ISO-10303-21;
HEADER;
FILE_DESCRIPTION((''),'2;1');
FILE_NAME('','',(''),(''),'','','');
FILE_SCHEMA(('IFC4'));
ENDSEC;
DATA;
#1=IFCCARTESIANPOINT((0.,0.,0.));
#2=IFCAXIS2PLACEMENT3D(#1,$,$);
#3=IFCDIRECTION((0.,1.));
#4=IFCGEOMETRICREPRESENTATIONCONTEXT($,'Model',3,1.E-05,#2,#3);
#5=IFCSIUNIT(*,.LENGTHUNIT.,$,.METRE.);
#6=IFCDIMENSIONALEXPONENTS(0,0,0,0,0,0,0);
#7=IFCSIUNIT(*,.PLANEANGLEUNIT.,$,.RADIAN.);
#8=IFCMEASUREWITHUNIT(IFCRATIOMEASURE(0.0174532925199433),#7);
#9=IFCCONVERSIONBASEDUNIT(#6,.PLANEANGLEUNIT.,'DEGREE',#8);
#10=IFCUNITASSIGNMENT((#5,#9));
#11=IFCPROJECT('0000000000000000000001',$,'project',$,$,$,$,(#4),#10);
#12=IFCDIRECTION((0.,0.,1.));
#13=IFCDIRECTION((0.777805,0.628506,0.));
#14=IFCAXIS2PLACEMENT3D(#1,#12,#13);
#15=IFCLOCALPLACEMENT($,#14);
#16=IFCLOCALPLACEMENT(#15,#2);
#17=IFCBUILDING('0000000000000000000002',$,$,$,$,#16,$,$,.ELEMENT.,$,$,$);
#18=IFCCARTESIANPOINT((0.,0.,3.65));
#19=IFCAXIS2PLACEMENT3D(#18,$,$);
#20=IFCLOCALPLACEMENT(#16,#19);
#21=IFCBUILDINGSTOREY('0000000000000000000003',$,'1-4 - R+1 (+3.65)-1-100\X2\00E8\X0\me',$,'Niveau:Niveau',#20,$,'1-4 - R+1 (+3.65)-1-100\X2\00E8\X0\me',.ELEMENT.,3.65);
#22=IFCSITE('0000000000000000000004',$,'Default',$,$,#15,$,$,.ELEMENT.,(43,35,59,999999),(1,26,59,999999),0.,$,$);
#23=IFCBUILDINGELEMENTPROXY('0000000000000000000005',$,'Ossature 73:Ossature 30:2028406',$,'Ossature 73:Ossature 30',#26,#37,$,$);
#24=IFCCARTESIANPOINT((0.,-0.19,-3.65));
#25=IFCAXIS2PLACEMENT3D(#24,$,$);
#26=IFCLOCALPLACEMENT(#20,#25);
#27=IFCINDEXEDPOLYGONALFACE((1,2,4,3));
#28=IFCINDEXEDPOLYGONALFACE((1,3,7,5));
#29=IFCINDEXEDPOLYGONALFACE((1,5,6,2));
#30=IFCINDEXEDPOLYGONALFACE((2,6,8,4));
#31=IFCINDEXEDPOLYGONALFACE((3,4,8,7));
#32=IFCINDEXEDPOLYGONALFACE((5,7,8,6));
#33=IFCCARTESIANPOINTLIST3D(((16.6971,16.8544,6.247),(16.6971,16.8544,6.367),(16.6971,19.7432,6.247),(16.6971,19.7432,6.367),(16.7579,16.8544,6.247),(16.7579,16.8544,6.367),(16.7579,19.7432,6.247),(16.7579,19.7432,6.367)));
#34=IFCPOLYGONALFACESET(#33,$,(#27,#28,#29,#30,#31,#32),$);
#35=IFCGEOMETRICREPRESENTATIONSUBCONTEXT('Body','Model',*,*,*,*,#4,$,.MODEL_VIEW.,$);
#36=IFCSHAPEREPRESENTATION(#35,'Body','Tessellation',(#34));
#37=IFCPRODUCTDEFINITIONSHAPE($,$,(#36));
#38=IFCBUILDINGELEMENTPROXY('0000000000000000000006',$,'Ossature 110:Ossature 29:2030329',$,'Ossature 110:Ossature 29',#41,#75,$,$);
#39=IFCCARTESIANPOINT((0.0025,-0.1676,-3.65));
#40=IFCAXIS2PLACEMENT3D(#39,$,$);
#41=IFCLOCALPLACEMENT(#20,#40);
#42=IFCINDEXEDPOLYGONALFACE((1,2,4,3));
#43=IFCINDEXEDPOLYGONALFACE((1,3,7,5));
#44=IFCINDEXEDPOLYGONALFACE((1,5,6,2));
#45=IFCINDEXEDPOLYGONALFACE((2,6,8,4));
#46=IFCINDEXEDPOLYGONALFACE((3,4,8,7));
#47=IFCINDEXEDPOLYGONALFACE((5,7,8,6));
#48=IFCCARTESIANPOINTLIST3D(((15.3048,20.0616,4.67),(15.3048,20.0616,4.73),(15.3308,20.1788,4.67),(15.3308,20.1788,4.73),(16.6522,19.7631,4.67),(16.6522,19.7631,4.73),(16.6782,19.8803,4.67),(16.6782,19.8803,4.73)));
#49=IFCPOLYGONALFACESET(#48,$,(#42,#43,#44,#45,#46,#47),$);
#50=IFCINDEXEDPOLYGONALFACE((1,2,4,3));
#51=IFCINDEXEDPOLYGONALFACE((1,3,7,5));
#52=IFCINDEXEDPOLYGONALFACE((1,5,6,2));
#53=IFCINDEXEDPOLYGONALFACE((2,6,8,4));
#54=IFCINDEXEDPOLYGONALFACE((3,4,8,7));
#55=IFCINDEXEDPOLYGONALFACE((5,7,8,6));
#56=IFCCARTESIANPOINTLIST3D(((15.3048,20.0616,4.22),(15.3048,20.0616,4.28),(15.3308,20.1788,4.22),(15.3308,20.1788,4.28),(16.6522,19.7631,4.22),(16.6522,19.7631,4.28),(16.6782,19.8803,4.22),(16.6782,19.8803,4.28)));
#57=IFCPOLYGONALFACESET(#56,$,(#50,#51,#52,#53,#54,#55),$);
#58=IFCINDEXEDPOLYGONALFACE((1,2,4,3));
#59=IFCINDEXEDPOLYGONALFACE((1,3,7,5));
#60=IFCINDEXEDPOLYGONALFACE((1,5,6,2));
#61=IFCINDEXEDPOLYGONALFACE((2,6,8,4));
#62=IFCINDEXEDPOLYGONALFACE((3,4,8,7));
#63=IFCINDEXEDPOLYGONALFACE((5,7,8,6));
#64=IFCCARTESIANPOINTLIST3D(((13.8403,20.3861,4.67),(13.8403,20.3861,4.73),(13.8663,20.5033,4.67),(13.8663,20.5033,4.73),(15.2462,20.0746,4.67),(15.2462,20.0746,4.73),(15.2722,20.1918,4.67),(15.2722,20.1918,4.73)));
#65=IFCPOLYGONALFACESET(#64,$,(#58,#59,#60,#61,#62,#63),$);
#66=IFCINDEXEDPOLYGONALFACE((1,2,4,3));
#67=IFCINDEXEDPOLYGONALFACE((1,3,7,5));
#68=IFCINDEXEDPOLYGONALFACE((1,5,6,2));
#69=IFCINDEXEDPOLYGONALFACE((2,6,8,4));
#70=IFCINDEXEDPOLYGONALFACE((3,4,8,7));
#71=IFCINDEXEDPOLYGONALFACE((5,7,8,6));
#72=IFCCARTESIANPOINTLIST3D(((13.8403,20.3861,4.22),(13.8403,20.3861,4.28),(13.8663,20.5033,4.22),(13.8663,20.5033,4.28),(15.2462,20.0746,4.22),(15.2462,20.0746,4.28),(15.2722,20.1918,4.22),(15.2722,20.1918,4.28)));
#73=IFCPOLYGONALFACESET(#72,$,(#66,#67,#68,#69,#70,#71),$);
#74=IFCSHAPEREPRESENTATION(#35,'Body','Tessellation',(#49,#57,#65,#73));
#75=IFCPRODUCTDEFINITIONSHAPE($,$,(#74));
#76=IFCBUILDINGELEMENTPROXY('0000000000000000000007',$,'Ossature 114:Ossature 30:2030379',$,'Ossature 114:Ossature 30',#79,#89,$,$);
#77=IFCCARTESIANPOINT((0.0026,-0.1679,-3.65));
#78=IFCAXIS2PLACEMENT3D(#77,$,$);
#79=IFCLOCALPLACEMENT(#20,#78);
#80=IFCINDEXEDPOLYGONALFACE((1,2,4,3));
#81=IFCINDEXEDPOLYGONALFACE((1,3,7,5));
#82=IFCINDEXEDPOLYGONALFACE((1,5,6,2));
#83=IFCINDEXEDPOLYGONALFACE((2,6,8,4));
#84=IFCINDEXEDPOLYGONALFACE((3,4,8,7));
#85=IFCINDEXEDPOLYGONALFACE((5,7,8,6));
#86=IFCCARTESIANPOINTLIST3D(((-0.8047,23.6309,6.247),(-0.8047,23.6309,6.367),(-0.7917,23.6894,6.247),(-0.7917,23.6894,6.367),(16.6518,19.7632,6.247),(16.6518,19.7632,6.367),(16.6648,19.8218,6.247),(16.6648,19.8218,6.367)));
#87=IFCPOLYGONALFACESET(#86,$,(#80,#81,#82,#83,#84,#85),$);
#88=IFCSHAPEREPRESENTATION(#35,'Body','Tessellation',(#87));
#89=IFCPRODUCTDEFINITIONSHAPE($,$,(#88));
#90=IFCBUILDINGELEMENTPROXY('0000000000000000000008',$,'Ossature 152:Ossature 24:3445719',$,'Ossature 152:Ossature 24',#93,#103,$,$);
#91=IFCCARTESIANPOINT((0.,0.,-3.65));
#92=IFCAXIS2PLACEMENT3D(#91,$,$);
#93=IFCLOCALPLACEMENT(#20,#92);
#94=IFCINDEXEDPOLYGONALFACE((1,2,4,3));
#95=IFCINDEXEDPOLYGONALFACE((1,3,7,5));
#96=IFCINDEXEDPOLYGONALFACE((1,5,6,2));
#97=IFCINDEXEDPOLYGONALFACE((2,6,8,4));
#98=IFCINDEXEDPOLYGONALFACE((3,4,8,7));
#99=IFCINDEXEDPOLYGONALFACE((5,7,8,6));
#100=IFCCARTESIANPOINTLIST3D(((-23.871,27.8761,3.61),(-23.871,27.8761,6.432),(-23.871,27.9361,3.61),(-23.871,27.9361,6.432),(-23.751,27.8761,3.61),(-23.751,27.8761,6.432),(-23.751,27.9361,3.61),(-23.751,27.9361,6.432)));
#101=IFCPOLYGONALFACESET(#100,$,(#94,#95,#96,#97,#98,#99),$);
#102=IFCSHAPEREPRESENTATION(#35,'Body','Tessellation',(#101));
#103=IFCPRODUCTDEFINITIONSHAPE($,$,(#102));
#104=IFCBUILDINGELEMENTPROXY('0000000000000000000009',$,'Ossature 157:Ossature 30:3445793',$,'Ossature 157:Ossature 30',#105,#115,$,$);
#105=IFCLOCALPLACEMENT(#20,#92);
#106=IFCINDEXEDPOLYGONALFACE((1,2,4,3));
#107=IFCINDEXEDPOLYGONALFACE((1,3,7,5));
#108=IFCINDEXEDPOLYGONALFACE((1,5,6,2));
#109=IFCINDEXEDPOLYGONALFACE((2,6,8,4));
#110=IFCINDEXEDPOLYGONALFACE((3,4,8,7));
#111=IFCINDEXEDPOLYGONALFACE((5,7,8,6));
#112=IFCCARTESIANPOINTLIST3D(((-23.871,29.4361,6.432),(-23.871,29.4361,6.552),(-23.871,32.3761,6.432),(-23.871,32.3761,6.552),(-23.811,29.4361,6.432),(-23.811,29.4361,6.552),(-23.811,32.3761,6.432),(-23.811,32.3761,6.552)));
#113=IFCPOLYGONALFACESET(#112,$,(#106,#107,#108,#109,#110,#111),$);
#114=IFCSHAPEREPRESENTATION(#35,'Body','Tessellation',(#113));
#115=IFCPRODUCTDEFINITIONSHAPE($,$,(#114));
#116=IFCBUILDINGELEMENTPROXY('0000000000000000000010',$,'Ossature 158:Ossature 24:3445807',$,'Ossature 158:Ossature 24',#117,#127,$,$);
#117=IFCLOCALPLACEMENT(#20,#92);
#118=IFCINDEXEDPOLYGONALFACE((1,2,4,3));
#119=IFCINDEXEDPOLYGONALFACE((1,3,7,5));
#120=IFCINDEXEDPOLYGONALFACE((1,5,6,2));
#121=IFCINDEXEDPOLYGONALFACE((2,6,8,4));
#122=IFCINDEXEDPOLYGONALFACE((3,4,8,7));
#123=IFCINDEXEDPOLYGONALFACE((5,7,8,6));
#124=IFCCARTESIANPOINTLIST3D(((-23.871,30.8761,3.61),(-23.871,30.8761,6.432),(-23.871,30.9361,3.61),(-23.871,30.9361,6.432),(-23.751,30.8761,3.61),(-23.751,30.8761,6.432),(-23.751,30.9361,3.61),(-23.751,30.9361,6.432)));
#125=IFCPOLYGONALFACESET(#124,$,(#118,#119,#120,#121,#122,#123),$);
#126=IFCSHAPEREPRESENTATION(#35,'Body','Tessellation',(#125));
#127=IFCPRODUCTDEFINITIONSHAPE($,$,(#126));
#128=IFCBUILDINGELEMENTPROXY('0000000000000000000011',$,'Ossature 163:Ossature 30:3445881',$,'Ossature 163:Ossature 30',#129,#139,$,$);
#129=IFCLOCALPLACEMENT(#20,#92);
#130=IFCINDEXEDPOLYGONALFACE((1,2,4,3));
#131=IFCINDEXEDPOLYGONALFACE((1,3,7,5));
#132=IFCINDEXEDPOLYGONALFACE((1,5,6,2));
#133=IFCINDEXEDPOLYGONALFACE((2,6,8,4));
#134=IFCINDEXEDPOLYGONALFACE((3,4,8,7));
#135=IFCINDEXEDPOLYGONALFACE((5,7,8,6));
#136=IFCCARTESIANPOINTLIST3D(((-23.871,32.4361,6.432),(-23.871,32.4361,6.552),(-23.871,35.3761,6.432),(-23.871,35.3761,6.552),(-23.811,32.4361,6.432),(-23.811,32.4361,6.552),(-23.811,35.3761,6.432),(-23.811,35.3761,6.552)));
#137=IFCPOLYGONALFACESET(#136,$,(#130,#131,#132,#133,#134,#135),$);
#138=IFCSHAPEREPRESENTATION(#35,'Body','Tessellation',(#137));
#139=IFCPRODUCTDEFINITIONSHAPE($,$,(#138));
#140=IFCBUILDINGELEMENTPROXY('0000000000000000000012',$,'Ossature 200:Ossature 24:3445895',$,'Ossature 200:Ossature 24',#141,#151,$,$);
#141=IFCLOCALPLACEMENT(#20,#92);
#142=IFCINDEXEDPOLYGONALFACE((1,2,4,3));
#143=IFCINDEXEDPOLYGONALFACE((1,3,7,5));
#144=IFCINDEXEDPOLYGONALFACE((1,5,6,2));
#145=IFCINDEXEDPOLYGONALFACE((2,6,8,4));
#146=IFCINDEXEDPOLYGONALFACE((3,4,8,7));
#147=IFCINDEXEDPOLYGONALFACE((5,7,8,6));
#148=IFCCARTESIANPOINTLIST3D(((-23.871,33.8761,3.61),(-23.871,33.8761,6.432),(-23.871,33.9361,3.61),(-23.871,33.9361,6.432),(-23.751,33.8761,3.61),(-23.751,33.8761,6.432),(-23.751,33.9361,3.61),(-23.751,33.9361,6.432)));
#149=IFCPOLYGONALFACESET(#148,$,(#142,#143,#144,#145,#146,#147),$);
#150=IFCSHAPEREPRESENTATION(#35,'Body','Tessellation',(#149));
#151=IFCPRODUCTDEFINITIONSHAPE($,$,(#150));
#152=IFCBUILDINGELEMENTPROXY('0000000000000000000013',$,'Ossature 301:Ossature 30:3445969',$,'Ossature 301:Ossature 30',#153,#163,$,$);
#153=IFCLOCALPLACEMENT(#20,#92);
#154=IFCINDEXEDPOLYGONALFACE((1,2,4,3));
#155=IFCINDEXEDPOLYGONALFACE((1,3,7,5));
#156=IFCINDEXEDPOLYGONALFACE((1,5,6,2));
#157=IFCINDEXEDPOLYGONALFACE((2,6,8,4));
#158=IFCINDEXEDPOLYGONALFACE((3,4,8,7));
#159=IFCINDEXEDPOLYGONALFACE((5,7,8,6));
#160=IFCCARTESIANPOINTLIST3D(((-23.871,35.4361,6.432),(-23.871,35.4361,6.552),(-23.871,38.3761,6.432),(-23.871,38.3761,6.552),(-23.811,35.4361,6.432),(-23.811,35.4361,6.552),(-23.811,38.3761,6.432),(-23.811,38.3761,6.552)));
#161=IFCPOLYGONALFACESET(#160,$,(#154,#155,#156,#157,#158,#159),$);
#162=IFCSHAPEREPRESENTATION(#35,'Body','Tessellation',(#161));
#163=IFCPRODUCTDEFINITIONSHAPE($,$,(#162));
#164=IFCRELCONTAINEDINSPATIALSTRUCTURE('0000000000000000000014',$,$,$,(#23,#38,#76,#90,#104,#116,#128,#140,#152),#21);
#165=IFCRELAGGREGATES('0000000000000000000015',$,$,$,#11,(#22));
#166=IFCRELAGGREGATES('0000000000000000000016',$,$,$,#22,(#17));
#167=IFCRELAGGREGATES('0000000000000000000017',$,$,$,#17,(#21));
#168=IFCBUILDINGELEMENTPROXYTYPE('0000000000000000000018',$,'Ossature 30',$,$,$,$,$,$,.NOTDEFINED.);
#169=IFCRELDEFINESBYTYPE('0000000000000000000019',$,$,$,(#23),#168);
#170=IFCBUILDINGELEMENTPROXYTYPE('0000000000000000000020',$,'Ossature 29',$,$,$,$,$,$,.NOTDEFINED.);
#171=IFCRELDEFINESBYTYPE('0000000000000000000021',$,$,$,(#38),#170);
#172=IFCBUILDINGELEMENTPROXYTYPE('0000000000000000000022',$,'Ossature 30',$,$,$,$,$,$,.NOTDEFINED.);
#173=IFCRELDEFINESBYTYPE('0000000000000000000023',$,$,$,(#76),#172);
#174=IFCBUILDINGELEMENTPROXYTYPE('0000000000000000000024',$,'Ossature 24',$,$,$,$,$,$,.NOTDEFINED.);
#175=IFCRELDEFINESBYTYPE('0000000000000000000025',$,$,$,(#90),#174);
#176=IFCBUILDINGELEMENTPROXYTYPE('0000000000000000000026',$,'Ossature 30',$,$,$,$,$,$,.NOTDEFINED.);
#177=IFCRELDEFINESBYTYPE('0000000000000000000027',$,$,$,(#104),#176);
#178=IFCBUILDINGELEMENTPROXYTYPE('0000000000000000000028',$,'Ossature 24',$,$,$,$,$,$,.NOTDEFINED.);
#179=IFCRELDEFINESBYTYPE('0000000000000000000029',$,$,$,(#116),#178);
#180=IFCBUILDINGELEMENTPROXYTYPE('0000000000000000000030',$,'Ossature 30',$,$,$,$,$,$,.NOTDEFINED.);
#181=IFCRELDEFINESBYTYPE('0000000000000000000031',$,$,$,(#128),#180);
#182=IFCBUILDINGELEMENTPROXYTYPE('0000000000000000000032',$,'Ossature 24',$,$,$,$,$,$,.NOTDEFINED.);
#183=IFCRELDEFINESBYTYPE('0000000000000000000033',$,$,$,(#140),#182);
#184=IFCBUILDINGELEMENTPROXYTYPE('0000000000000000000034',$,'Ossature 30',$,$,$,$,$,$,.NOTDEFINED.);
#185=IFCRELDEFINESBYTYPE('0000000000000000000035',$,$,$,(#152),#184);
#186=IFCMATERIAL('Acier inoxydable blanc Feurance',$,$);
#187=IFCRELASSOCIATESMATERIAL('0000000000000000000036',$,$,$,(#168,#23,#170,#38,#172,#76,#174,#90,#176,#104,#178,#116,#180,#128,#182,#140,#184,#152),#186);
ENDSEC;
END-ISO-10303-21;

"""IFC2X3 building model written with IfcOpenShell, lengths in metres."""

from ifc_helpers import new_model, entity, si_unit, converted_unit, direction, frame, frame_2d, origin, origin_2d_with_axis, place, context, subcontext, project, spatial, rectangle, extrude, source, transform, mapped, material, type_object, type_shapes, element, save


model = new_model("IFC2X3")

# Units and contexts
model_context = context("Model", 3, precision=1e-05, world=origin(), true_north=direction((0.0, 1.0)))
body_context = subcontext(model_context, "Body", "Model", "MODEL_VIEW")
ifc_project = project(units=[si_unit("LENGTHUNIT", "METRE"), converted_unit("PLANEANGLEUNIT", "DEGREE", entity("IfcRatioMeasure", 0.0174532925199433), si_unit("PLANEANGLEUNIT", "RADIAN"), dimensions=[0, 0, 0, 0, 0, 0, 0])], contexts=[model_context])

# Site, building, storey
site_placement = place(None, frame((0.0, 0.0, 0.0), z_axis=(0.0, 0.0, 1.0), x_axis=(0.777805, 0.628506, 0.0)))
site = spatial("IfcSite", under=ifc_project, at=site_placement, Name="Default", CompositionType="ELEMENT", RefLatitude=(43, 35, 59, 999999), RefLongitude=(1, 26, 59, 999999), RefElevation=0.0)
building_placement = place(site_placement, origin())
building = spatial("IfcBuilding", under=site, at=building_placement, CompositionType="ELEMENT")
storey_placement = place(building_placement, frame((0.0, 0.0, 3.65)))
storey = spatial("IfcBuildingStorey", under=building, at=storey_placement, Name="1-4 - R+1 (+3.65)-1-100ème", ObjectType="Niveau:Niveau", LongName="1-4 - R+1 (+3.65)-1-100ème", CompositionType="ELEMENT", Elevation=3.65)

# Building element proxies
ifc_material_1 = material(Name="Acier inoxydable blanc Feurance")
building_element_proxy_type_1 = type_object("IfcBuildingElementProxyType", Name="Ossature 30", PredefinedType="NOTDEFINED", material=ifc_material_1)
shared_shape_1 = source(origin(), body_context, "Body", "SweptSolid", [
    extrude(rectangle(XDim=2.8888, YDim=0.0607, at=frame_2d((0.0, 0.0), x_axis=(1.0, 0.0))), frame((16.7275, 18.2988, 6.247), z_axis=(0.0, 0.0, 1.0), x_axis=(0.0, -1.0, 0.0)), (0.0, 0.0, 1.0), 0.12),
])
type_shapes(building_element_proxy_type_1, [shared_shape_1])
proxy_1_placement = place(storey_placement, frame((0.0, -0.19, -3.65)))
element("IfcBuildingElementProxy", 1, at=proxy_1_placement, inside=storey, type_object=building_element_proxy_type_1, material=ifc_material_1, Name="Ossature 73:Ossature 30:2028406", ObjectType="Ossature 73:Ossature 30", context=body_context, shape_type="MappedRepresentation", body=[
    mapped(shared_shape_1, transform((0.0, 0.0, 0.0), scale=1.0)),
])
building_element_proxy_type_2 = type_object("IfcBuildingElementProxyType", Name="Ossature 29", PredefinedType="NOTDEFINED", material=ifc_material_1)
shared_shape_2 = source(origin(), body_context, "Body", "SweptSolid", [
    extrude(rectangle(XDim=1.3801, YDim=0.12, at=origin_2d_with_axis()), frame((15.9915, 19.971, 4.67), z_axis=(0.0, 0.0, 1.0), x_axis=(-0.976324, 0.216314, 0.0)), (0.0, 0.0, 1.0), 0.06),
    extrude(rectangle(XDim=1.3801, YDim=0.12, at=frame_2d((0.0, 0.0), x_axis=(1.0, 0.0))), frame((15.9915, 19.971, 4.22), z_axis=(0.0, 0.0, 1.0), x_axis=(-0.976324, 0.216314, 0.0)), (0.0, 0.0, 1.0), 0.06),
    extrude(rectangle(XDim=1.44, YDim=0.12, at=frame_2d((0.0, 0.0), x_axis=(1.0, 0.0))), frame((14.5563, 20.289, 4.67), z_axis=(0.0, 0.0, 1.0), x_axis=(0.976324, -0.216314, 0.0)), (0.0, 0.0, 1.0), 0.06),
    extrude(rectangle(XDim=1.44, YDim=0.12, at=frame_2d((0.0, 0.0), x_axis=(1.0, 0.0))), frame((14.5563, 20.289, 4.22), z_axis=(0.0, 0.0, 1.0), x_axis=(0.976324, -0.216314, 0.0)), (0.0, 0.0, 1.0), 0.06),
])
type_shapes(building_element_proxy_type_2, [shared_shape_2])
proxy_2_placement = place(storey_placement, frame((0.0025, -0.1676, -3.65)))
element("IfcBuildingElementProxy", 2, at=proxy_2_placement, inside=storey, type_object=building_element_proxy_type_2, material=ifc_material_1, Name="Ossature 110:Ossature 29:2030329", ObjectType="Ossature 110:Ossature 29", context=body_context, shape_type="MappedRepresentation", body=[
    mapped(shared_shape_2, transform((0.0, 0.0, 0.0), scale=1.0)),
])
building_element_proxy_type_3 = type_object("IfcBuildingElementProxyType", Name="Ossature 30", PredefinedType="NOTDEFINED", material=ifc_material_1)
shared_shape_3 = source(origin(), body_context, "Body", "SweptSolid", [
    extrude(rectangle(XDim=17.8798, YDim=0.06, at=frame_2d((0.0, 0.0), x_axis=(1.0, 0.0))), frame((7.93, 21.7263, 6.247), z_axis=(0.0, 0.0, 1.0), x_axis=(0.976324, -0.216314, 0.0)), (0.0, 0.0, 1.0), 0.12),
])
type_shapes(building_element_proxy_type_3, [shared_shape_3])
proxy_3_placement = place(storey_placement, frame((0.0026, -0.1679, -3.65)))
element("IfcBuildingElementProxy", 3, at=proxy_3_placement, inside=storey, type_object=building_element_proxy_type_3, material=ifc_material_1, Name="Ossature 114:Ossature 30:2030379", ObjectType="Ossature 114:Ossature 30", context=body_context, shape_type="MappedRepresentation", body=[
    mapped(shared_shape_3, transform((0.0, 0.0, 0.0), scale=1.0)),
])
building_element_proxy_type_4 = type_object("IfcBuildingElementProxyType", Name="Ossature 24", PredefinedType="NOTDEFINED", material=ifc_material_1)
shared_shape_4 = source(origin(), body_context, "Body", "SweptSolid", [
    extrude(rectangle(XDim=0.06, YDim=0.12, at=frame_2d((0.0, 0.0), x_axis=(1.0, 0.0))), frame((-23.811, 27.9061, 3.61), z_axis=(0.0, 0.0, 1.0), x_axis=(0.0, -1.0, 0.0)), (0.0, 0.0, 1.0), 2.822),
])
type_shapes(building_element_proxy_type_4, [shared_shape_4])
proxy_4_placement = place(storey_placement, frame((0.0, 0.0, -3.65)))
element("IfcBuildingElementProxy", 4, at=proxy_4_placement, inside=storey, type_object=building_element_proxy_type_4, material=ifc_material_1, Name="Ossature 152:Ossature 24:3445719", ObjectType="Ossature 152:Ossature 24", context=body_context, shape_type="MappedRepresentation", body=[
    mapped(shared_shape_4, transform((0.0, 0.0, 0.0), scale=1.0)),
])
building_element_proxy_type_5 = type_object("IfcBuildingElementProxyType", Name="Ossature 30", PredefinedType="NOTDEFINED", material=ifc_material_1)
shared_shape_5 = source(origin(), body_context, "Body", "SweptSolid", [
    extrude(rectangle(XDim=2.94, YDim=0.06, at=origin_2d_with_axis()), frame((-23.841, 30.9061, 6.432), z_axis=(0.0, 0.0, 1.0), x_axis=(0.0, -1.0, 0.0)), (0.0, 0.0, 1.0), 0.12),
])
type_shapes(building_element_proxy_type_5, [shared_shape_5])
proxy_5_placement = place(storey_placement, frame((0.0, 0.0, -3.65)))
element("IfcBuildingElementProxy", 5, at=proxy_5_placement, inside=storey, type_object=building_element_proxy_type_5, material=ifc_material_1, Name="Ossature 157:Ossature 30:3445793", ObjectType="Ossature 157:Ossature 30", context=body_context, shape_type="MappedRepresentation", body=[
    mapped(shared_shape_5, transform((0.0, 0.0, 0.0), scale=1.0)),
])
building_element_proxy_type_6 = type_object("IfcBuildingElementProxyType", Name="Ossature 24", PredefinedType="NOTDEFINED", material=ifc_material_1)
shared_shape_6 = source(origin(), body_context, "Body", "SweptSolid", [
    extrude(rectangle(XDim=0.06, YDim=0.12, at=frame_2d((0.0, 0.0), x_axis=(1.0, 0.0))), frame((-23.811, 30.9061, 3.61), z_axis=(0.0, 0.0, 1.0), x_axis=(0.0, -1.0, 0.0)), (0.0, 0.0, 1.0), 2.822),
])
type_shapes(building_element_proxy_type_6, [shared_shape_6])
proxy_6_placement = place(storey_placement, frame((0.0, 0.0, -3.65)))
element("IfcBuildingElementProxy", 6, at=proxy_6_placement, inside=storey, type_object=building_element_proxy_type_6, material=ifc_material_1, Name="Ossature 158:Ossature 24:3445807", ObjectType="Ossature 158:Ossature 24", context=body_context, shape_type="MappedRepresentation", body=[
    mapped(shared_shape_6, transform((0.0, 0.0, 0.0), scale=1.0)),
])
building_element_proxy_type_7 = type_object("IfcBuildingElementProxyType", Name="Ossature 30", PredefinedType="NOTDEFINED", material=ifc_material_1)
shared_shape_7 = source(origin(), body_context, "Body", "SweptSolid", [
    extrude(rectangle(XDim=2.94, YDim=0.06, at=origin_2d_with_axis()), frame((-23.841, 33.9061, 6.432), z_axis=(0.0, 0.0, 1.0), x_axis=(0.0, -1.0, 0.0)), (0.0, 0.0, 1.0), 0.12),
])
type_shapes(building_element_proxy_type_7, [shared_shape_7])
proxy_7_placement = place(storey_placement, frame((0.0, 0.0, -3.65)))
element("IfcBuildingElementProxy", 7, at=proxy_7_placement, inside=storey, type_object=building_element_proxy_type_7, material=ifc_material_1, Name="Ossature 163:Ossature 30:3445881", ObjectType="Ossature 163:Ossature 30", context=body_context, shape_type="MappedRepresentation", body=[
    mapped(shared_shape_7, transform((0.0, 0.0, 0.0), scale=1.0)),
])
building_element_proxy_type_8 = type_object("IfcBuildingElementProxyType", Name="Ossature 24", PredefinedType="NOTDEFINED", material=ifc_material_1)
shared_shape_8 = source(origin(), body_context, "Body", "SweptSolid", [
    extrude(rectangle(XDim=0.06, YDim=0.12, at=frame_2d((0.0, 0.0), x_axis=(1.0, 0.0))), frame((-23.811, 33.9061, 3.61), z_axis=(0.0, 0.0, 1.0), x_axis=(0.0, -1.0, 0.0)), (0.0, 0.0, 1.0), 2.822),
])
type_shapes(building_element_proxy_type_8, [shared_shape_8])
proxy_8_placement = place(storey_placement, frame((0.0, 0.0, -3.65)))
element("IfcBuildingElementProxy", 8, at=proxy_8_placement, inside=storey, type_object=building_element_proxy_type_8, material=ifc_material_1, Name="Ossature 200:Ossature 24:3445895", ObjectType="Ossature 200:Ossature 24", context=body_context, shape_type="MappedRepresentation", body=[
    mapped(shared_shape_8, transform((0.0, 0.0, 0.0), scale=1.0)),
])
building_element_proxy_type_9 = type_object("IfcBuildingElementProxyType", Name="Ossature 30", PredefinedType="NOTDEFINED", material=ifc_material_1)
shared_shape_9 = source(origin(), body_context, "Body", "SweptSolid", [
    extrude(rectangle(XDim=2.94, YDim=0.06, at=origin_2d_with_axis()), frame((-23.841, 36.9061, 6.432), z_axis=(0.0, 0.0, 1.0), x_axis=(0.0, -1.0, 0.0)), (0.0, 0.0, 1.0), 0.12),
])
type_shapes(building_element_proxy_type_9, [shared_shape_9])
proxy_9_placement = place(storey_placement, frame((0.0, 0.0, -3.65)))
element("IfcBuildingElementProxy", 9, at=proxy_9_placement, inside=storey, type_object=building_element_proxy_type_9, material=ifc_material_1, Name="Ossature 301:Ossature 30:3445969", ObjectType="Ossature 301:Ossature 30", context=body_context, shape_type="MappedRepresentation", body=[
    mapped(shared_shape_9, transform((0.0, 0.0, 0.0), scale=1.0)),
])

save(model, "model.ifc")
